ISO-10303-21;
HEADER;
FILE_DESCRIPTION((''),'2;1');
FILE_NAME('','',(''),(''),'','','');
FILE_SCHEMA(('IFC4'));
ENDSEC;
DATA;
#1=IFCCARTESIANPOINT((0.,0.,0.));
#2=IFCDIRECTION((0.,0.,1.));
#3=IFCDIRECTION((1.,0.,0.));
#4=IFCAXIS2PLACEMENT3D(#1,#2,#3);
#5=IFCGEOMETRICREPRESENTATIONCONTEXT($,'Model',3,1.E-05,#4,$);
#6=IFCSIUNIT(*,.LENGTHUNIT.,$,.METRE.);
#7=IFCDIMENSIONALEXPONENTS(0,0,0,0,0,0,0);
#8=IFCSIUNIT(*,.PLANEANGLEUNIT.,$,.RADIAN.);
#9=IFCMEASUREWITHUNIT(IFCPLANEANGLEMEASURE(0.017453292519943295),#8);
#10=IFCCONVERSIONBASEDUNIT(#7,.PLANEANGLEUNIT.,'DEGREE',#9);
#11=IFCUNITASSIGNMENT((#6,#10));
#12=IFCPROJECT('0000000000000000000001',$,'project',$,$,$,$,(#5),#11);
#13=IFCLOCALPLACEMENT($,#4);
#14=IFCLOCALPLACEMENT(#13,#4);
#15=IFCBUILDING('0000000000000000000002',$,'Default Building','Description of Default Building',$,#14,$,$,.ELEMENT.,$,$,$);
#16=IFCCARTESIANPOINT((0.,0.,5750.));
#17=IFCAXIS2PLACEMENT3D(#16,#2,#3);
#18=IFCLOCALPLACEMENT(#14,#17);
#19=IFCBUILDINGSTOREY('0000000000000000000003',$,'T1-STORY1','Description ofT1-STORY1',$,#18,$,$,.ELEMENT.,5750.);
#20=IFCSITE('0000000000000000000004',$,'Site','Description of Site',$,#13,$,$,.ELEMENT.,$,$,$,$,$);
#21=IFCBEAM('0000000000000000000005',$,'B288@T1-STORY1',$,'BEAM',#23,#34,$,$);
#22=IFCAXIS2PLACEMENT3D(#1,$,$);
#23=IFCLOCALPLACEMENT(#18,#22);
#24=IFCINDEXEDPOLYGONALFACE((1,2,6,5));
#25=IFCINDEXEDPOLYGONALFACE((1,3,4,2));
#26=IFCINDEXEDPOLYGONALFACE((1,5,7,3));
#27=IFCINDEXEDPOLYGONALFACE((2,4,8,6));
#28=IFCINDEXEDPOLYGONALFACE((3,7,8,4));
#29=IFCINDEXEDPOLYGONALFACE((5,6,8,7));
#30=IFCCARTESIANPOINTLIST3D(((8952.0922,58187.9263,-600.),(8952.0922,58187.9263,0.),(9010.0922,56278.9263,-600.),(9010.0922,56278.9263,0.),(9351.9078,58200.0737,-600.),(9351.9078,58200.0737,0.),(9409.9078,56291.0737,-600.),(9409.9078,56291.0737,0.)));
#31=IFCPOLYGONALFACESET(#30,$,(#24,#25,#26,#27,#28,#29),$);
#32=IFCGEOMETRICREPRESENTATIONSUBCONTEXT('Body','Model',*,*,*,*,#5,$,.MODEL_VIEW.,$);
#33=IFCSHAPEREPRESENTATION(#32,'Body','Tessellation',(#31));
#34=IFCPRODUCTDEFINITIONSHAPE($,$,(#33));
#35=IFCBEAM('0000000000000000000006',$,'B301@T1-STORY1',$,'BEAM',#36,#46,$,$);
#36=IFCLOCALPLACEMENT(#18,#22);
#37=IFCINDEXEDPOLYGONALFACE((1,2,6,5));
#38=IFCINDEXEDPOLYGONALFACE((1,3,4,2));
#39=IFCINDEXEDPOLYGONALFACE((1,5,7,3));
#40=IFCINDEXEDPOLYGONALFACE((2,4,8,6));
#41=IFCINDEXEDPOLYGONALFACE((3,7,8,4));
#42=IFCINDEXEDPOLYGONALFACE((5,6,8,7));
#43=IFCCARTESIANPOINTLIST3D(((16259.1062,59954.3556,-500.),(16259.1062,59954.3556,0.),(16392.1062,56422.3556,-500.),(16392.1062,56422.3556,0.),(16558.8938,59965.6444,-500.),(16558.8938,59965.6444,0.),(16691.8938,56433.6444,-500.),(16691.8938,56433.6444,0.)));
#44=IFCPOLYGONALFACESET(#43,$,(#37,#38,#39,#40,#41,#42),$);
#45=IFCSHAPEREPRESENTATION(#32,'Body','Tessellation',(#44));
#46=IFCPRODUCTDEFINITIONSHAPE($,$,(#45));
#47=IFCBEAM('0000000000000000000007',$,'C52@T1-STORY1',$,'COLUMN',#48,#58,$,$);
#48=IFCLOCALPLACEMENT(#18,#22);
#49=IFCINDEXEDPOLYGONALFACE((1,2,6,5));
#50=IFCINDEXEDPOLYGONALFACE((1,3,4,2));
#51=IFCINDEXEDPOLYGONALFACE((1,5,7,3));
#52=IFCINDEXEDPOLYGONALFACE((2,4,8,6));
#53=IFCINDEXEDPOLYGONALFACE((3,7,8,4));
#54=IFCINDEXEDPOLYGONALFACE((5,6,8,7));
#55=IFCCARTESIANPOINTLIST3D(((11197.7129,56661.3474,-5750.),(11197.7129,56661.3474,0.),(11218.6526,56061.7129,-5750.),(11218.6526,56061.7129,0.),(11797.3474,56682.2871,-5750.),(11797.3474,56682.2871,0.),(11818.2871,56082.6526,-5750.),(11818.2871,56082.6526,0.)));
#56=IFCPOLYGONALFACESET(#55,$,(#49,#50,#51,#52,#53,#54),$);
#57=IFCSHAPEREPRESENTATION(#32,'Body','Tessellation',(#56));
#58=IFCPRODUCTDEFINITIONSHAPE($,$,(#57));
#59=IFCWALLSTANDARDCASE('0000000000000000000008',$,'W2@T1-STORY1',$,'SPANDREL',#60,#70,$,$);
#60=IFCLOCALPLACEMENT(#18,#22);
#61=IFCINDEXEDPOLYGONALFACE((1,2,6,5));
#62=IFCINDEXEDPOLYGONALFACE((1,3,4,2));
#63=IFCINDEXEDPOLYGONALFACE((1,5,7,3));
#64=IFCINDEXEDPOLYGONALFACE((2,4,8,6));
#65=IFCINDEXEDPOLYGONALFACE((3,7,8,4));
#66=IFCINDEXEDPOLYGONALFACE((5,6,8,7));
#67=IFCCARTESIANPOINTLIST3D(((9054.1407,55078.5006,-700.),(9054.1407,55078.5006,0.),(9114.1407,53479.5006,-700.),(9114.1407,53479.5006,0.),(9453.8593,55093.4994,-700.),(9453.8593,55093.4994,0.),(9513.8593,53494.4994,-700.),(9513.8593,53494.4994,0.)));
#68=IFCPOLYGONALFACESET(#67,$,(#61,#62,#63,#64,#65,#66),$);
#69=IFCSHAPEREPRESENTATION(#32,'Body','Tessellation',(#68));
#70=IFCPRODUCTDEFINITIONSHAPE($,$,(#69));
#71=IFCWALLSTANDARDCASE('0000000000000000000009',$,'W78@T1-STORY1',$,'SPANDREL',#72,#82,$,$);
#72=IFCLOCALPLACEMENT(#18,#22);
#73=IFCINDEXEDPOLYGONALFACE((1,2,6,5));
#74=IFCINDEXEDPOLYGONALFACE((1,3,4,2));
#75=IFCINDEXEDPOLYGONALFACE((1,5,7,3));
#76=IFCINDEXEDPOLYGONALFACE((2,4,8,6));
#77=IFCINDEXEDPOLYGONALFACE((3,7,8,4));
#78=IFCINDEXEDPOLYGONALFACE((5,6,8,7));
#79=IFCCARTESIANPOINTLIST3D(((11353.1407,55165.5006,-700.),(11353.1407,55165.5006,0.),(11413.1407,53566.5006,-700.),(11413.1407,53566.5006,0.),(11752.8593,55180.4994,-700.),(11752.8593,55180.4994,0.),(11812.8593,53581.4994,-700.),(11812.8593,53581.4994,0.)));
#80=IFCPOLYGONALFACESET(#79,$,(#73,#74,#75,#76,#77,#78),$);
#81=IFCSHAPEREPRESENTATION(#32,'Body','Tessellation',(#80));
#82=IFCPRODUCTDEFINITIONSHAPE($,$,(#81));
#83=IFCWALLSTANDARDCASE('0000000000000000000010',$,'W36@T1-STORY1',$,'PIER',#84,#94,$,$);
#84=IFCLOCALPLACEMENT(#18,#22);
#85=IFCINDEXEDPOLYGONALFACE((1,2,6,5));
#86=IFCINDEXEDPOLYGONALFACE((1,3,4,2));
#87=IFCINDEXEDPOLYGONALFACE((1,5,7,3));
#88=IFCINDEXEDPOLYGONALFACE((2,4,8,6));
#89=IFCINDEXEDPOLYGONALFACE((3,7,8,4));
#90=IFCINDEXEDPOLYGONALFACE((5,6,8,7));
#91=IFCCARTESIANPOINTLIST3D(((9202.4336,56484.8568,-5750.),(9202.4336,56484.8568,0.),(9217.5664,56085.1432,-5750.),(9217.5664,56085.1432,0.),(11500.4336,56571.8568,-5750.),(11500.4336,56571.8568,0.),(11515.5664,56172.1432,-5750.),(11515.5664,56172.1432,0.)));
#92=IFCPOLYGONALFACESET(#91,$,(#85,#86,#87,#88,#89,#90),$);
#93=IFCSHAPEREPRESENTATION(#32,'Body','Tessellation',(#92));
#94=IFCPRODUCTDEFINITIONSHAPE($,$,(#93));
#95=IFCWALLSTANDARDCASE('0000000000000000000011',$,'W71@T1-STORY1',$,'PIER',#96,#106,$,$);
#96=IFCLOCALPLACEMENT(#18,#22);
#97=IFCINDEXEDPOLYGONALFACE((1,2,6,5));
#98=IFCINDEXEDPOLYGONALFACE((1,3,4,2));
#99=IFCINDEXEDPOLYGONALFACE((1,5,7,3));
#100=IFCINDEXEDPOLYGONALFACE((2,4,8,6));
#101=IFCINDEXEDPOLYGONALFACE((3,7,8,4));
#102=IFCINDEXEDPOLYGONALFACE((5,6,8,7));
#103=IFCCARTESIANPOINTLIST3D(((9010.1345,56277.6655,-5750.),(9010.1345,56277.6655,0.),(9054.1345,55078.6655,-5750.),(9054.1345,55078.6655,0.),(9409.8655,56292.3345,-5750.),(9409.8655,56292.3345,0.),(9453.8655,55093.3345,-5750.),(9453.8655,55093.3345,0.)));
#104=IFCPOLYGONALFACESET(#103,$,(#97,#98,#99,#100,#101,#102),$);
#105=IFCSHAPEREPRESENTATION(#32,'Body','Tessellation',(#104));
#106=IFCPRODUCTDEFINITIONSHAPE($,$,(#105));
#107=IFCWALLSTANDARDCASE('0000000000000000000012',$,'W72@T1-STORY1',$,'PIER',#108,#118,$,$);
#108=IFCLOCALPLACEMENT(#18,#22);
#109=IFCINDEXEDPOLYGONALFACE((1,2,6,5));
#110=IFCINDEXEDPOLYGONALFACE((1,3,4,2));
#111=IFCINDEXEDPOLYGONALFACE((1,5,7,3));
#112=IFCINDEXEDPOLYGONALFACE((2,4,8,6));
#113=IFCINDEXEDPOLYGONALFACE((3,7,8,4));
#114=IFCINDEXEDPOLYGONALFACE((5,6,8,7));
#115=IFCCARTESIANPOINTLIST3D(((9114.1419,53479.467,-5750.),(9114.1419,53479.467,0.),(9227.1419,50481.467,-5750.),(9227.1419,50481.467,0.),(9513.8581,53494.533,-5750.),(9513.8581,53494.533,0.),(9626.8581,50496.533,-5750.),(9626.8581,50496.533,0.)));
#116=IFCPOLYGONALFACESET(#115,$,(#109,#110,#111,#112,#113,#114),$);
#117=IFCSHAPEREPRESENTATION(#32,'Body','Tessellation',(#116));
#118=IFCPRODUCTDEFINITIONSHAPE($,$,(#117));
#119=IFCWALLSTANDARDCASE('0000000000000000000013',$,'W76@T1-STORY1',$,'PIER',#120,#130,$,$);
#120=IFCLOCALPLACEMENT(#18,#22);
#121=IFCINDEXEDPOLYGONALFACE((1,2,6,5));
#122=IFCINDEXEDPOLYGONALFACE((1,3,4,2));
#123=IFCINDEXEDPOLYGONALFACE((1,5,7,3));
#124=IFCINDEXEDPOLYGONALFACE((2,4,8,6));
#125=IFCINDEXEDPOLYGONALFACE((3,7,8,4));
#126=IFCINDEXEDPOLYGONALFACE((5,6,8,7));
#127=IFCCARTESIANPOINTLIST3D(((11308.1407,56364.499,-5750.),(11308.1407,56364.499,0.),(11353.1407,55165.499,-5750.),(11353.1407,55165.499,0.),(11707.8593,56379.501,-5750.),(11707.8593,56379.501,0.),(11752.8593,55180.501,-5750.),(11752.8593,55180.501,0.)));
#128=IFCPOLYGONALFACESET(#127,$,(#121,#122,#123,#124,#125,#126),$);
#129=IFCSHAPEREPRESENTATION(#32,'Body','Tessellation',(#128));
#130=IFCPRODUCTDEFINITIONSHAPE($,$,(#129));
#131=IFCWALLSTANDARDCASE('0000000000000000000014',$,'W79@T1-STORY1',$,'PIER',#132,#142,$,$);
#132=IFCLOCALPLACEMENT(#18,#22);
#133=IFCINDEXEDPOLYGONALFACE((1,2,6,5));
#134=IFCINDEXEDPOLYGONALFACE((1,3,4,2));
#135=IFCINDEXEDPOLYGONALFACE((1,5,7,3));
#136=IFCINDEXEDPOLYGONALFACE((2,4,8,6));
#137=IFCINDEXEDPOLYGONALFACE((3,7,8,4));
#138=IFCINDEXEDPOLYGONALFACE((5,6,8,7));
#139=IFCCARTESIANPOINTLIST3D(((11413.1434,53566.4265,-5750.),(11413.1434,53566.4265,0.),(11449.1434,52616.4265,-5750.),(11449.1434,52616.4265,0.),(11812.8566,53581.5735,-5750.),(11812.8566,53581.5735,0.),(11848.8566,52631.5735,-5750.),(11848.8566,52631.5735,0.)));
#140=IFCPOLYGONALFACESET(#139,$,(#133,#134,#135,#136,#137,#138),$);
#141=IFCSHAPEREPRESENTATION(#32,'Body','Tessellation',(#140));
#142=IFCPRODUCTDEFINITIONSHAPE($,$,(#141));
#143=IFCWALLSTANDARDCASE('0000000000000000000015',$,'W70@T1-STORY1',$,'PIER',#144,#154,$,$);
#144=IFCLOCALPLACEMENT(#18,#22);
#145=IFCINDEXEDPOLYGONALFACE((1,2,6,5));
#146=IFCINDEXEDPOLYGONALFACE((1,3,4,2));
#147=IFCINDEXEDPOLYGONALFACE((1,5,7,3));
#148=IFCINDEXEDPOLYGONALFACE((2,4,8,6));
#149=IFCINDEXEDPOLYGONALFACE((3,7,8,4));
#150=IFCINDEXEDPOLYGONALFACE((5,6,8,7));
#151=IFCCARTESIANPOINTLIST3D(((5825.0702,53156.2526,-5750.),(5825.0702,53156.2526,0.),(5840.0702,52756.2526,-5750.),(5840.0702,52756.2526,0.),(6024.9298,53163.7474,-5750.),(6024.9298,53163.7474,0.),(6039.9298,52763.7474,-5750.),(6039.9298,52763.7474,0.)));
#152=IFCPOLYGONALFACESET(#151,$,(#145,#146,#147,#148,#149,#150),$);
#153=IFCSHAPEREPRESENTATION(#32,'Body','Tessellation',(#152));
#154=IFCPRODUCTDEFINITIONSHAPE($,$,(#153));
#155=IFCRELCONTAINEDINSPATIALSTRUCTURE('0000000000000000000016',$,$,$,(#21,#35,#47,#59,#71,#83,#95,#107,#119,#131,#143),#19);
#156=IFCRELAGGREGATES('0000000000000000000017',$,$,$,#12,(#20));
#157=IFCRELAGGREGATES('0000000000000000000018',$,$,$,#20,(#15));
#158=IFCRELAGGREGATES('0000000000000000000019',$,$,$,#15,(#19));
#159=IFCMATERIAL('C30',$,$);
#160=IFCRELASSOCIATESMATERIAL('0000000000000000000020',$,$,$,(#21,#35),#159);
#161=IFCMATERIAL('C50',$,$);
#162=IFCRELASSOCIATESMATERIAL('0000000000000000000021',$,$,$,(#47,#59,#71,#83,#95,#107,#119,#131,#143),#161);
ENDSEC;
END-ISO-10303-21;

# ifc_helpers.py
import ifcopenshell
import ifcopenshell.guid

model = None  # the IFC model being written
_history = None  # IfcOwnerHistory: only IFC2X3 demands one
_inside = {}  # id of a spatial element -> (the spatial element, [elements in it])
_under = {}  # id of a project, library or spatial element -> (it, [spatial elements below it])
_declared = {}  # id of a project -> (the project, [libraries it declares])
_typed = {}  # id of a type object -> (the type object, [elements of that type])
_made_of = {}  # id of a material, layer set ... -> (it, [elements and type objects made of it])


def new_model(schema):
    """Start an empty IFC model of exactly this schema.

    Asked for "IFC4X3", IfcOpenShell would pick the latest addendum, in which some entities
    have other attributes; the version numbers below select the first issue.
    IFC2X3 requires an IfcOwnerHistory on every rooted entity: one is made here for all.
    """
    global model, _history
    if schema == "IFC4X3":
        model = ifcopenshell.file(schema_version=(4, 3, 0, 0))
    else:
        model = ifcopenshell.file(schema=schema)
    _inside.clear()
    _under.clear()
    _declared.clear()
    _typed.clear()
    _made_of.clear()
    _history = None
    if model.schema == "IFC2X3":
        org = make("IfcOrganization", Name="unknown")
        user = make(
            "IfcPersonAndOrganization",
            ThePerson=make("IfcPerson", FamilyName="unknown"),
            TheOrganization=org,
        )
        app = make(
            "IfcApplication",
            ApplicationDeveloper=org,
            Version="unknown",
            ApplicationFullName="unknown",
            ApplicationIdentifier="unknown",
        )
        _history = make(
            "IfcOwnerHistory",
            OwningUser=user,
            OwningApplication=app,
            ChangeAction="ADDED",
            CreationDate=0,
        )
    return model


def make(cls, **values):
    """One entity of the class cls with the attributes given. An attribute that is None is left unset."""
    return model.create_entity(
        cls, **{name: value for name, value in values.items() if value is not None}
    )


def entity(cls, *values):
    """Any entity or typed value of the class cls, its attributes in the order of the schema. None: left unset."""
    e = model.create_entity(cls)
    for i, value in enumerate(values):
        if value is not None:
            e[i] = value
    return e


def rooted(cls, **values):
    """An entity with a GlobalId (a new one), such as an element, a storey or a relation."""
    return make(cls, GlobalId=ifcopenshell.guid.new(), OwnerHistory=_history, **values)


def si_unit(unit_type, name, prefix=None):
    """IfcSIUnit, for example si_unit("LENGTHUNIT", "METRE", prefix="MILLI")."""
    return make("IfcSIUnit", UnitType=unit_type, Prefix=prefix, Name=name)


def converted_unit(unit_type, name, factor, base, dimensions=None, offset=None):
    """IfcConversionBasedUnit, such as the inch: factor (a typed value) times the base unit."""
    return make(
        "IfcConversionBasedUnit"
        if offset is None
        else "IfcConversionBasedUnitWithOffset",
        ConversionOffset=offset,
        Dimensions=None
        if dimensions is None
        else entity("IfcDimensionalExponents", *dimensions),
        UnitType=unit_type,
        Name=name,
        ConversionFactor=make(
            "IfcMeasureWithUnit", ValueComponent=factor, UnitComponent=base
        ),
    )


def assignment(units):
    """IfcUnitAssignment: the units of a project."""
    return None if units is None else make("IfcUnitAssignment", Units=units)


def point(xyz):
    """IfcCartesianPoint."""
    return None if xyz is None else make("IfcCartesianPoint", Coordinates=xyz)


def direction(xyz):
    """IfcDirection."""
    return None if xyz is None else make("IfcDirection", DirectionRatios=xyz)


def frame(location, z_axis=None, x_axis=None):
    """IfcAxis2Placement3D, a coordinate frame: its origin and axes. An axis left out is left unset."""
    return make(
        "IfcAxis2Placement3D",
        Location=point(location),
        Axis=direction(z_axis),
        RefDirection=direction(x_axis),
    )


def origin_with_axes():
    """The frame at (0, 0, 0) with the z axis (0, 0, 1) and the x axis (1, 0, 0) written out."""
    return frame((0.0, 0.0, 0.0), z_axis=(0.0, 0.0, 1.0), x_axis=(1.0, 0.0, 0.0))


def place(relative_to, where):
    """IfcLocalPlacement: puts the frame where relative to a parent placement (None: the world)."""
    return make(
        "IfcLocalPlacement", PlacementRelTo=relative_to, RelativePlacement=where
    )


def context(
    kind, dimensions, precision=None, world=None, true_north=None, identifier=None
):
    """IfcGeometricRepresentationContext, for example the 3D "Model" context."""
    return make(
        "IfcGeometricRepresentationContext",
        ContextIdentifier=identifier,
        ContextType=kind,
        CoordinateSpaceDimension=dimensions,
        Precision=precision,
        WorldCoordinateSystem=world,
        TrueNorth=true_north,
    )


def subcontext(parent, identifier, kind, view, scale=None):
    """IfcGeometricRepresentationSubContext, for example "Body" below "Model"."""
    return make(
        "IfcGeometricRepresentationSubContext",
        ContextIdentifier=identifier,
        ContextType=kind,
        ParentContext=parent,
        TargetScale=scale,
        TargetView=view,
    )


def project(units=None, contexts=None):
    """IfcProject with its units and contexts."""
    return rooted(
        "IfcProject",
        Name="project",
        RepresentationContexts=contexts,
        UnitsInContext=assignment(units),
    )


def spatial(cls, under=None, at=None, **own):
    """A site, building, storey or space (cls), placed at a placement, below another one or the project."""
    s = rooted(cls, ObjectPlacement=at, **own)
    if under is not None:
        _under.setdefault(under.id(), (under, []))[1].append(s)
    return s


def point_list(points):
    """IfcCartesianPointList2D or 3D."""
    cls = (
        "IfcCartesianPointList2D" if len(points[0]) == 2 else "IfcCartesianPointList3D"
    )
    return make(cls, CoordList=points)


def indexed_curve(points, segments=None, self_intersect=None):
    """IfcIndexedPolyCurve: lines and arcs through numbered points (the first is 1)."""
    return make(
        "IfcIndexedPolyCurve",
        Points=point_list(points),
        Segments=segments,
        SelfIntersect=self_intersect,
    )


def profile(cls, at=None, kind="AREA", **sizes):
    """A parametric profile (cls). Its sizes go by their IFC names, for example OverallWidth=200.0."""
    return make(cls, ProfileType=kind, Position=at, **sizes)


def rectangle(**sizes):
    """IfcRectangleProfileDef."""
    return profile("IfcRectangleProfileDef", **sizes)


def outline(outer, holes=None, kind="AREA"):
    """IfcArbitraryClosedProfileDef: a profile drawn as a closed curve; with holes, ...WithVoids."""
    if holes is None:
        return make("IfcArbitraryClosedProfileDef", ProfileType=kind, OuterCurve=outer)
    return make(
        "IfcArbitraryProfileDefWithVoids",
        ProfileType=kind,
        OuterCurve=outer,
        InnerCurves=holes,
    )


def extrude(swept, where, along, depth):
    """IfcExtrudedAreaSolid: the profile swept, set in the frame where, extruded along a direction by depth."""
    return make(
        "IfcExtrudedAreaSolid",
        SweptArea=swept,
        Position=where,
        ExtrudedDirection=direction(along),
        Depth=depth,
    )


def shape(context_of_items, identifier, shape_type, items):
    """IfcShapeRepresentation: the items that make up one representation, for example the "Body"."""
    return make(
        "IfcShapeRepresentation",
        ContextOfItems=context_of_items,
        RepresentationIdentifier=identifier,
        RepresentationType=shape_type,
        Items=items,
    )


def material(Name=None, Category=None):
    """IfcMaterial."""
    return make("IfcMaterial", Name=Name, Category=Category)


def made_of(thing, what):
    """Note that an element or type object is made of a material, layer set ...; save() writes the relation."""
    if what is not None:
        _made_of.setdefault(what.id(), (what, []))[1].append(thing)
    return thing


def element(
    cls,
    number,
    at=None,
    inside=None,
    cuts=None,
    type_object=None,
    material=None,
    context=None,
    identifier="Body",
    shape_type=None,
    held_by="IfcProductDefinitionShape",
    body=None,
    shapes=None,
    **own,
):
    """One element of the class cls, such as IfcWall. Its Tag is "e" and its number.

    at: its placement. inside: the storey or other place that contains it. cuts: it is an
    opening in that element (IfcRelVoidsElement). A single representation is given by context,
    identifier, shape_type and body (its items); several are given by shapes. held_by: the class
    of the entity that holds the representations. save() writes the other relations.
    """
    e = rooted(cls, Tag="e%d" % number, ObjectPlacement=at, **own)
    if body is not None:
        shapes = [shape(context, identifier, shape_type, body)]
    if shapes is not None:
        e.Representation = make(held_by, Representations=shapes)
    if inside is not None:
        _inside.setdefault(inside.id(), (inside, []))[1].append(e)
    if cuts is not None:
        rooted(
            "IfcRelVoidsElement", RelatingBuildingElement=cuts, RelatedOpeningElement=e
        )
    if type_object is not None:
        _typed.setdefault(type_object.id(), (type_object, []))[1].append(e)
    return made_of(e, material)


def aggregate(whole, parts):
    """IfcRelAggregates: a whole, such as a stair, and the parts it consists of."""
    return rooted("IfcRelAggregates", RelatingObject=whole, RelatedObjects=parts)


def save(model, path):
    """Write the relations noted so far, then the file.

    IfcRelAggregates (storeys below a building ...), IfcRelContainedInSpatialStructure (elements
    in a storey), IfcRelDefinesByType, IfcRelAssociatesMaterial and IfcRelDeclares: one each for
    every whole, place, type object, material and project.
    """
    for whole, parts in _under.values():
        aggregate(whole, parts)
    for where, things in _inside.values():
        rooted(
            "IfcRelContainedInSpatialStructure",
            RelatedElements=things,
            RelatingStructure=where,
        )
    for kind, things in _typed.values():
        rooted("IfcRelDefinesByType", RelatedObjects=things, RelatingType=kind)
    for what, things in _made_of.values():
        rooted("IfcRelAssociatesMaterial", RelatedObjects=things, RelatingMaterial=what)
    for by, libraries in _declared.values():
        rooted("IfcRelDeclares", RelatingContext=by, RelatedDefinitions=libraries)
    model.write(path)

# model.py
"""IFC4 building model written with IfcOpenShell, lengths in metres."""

from ifc_helpers import new_model, entity, si_unit, converted_unit, frame, origin_with_axes, place, context, subcontext, project, spatial, indexed_curve, rectangle, outline, extrude, material, element, save


model = new_model("IFC4")

# Units and contexts
model_context = context("Model", 3, precision=1e-05, world=origin_with_axes())
body_context = subcontext(model_context, "Body", "Model", "MODEL_VIEW")
ifc_project = project(units=[si_unit("LENGTHUNIT", "METRE"), converted_unit("PLANEANGLEUNIT", "DEGREE", entity("IfcPlaneAngleMeasure", 0.017453292519943295), si_unit("PLANEANGLEUNIT", "RADIAN"), dimensions=[0, 0, 0, 0, 0, 0, 0])], contexts=[model_context])

# Site, building, storey
site_placement = place(None, origin_with_axes())
site = spatial("IfcSite", under=ifc_project, at=site_placement, Name="Site", Description="Description of Site", CompositionType="ELEMENT")
building_placement = place(site_placement, origin_with_axes())
building = spatial("IfcBuilding", under=site, at=building_placement, Name="Default Building", Description="Description of Default Building", CompositionType="ELEMENT")
storey_placement = place(building_placement, frame((0.0, 0.0, 5750.0), z_axis=(0.0, 0.0, 1.0), x_axis=(1.0, 0.0, 0.0)))
storey = spatial("IfcBuildingStorey", under=building, at=storey_placement, Name="T1-STORY1", Description="Description ofT1-STORY1", CompositionType="ELEMENT", Elevation=5750.0)

# Beams
ifc_material_1 = material(Name="C30")
beam_1_placement = place(storey_placement, frame((9152.0, 58194.0, -300.0), z_axis=(0.030368, -0.999539, 0.0), x_axis=(0.999539, 0.030368, 0.0)))
element("IfcBeam", 1, at=beam_1_placement, inside=storey, material=ifc_material_1, Name="B288@T1-STORY1", ObjectType="BEAM", context=body_context, shape_type="SweptSolid", body=[
    extrude(rectangle(XDim=400.0, YDim=600.0), origin_with_axes(), (0.0, 0.0, 1.0), 1909.8809),
])
beam_2_placement = place(storey_placement, frame((16409.0, 59960.0, -250.0), z_axis=(0.037629, -0.999292, 0.0), x_axis=(0.999292, 0.037629, 0.0)))
element("IfcBeam", 2, at=beam_2_placement, inside=storey, material=ifc_material_1, Name="B301@T1-STORY1", ObjectType="BEAM", context=body_context, shape_type="SweptSolid", body=[
    extrude(rectangle(XDim=300.0, YDim=500.0), origin_with_axes(), (0.0, 0.0, 1.0), 3534.5032),
])
ifc_material_2 = material(Name="C50")
beam_3_placement = place(storey_placement, frame((11508.0, 56372.0, -5750.0), z_axis=(0.0, 0.0, 1.0), x_axis=(-0.999391, -0.034899, 0.0)))
element("IfcBeam", 3, at=beam_3_placement, inside=storey, material=ifc_material_2, Name="C52@T1-STORY1", ObjectType="COLUMN", context=body_context, shape_type="SweptSolid", body=[
    extrude(rectangle(XDim=600.0, YDim=600.0), origin_with_axes(), (0.0, 0.0, 1.0), 5750.0),
])

# Walls
for number, where, z_axis, x_axis, name in (
    (4, (9254.0, 55086.0, -700.0), (0.0, 0.0, 1.0), (0.037497, -0.999297, 0.0), "W2@T1-STORY1"),
    (5, (11553.0, 55173.0, -700.0), (0.0, 0.0, 1.0), (0.037497, -0.999297, 0.0), "W78@T1-STORY1"),
):
    element("IfcWallStandardCase", number, at=place(storey_placement, frame(where, z_axis=z_axis, x_axis=x_axis)), inside=storey, material=ifc_material_2, Name=name, ObjectType="SPANDREL", context=body_context, shape_type="SweptSolid", body=[
        extrude(outline(indexed_curve([(0.0, -200.0), (0.0, 200.0), (1600.1253, 200.0), (1600.1253, -200.0), (0.0, -200.0)], self_intersect=False)), origin_with_axes(), (0.0, 0.0, 1.0), 700.0),
    ])
wall_1_placement = place(storey_placement, frame((9210.0, 56285.0, -5750.0), z_axis=(0.0, 0.0, 1.0), x_axis=(0.999284, 0.037832, 0.0)))
element("IfcWallStandardCase", 6, at=wall_1_placement, inside=storey, material=ifc_material_2, Name="W36@T1-STORY1", ObjectType="PIER", context=body_context, shape_type="SweptSolid", body=[
    extrude(outline(indexed_curve([(0.0, -200.0), (0.0, 200.0), (2299.6463, 200.0), (2299.6463, -200.0), (0.0, -200.0)], self_intersect=False)), origin_with_axes(), (0.0, 0.0, 1.0), 5750.0),
])
wall_2_placement = place(storey_placement, frame((9210.0, 56285.0, -5750.0), z_axis=(0.0, 0.0, 1.0), x_axis=(0.036673, -0.999327, 0.0)))
element("IfcWallStandardCase", 7, at=wall_2_placement, inside=storey, material=ifc_material_2, Name="W71@T1-STORY1", ObjectType="PIER", context=body_context, shape_type="SweptSolid", body=[
    extrude(outline(indexed_curve([(0.0, -200.0), (0.0, 200.0), (1199.8071, 200.0), (1199.8071, -200.0), (0.0, -200.0)], self_intersect=False)), origin_with_axes(), (0.0, 0.0, 1.0), 5750.0),
])
wall_3_placement = place(storey_placement, frame((9314.0, 53487.0, -5750.0), z_axis=(0.0, 0.0, 1.0), x_axis=(0.037665, -0.99929, 0.0)))
element("IfcWallStandardCase", 8, at=wall_3_placement, inside=storey, material=ifc_material_2, Name="W72@T1-STORY1", ObjectType="PIER", context=body_context, shape_type="SweptSolid", body=[
    extrude(outline(indexed_curve([(0.0, -200.0), (0.0, 200.0), (3000.1288, 200.0), (3000.1288, -200.0), (0.0, -200.0)], self_intersect=False)), origin_with_axes(), (0.0, 0.0, 1.0), 5750.0),
])
wall_4_placement = place(storey_placement, frame((11508.0, 56372.0, -5750.0), z_axis=(0.0, 0.0, 1.0), x_axis=(0.037505, -0.999296, 0.0)))
element("IfcWallStandardCase", 9, at=wall_4_placement, inside=storey, material=ifc_material_2, Name="W76@T1-STORY1", ObjectType="PIER", context=body_context, shape_type="SweptSolid", body=[
    extrude(outline(indexed_curve([(0.0, -200.0), (0.0, 200.0), (1199.8442, 200.0), (1199.8442, -200.0), (0.0, -200.0)], self_intersect=False)), origin_with_axes(), (0.0, 0.0, 1.0), 5750.0),
])
wall_5_placement = place(storey_placement, frame((11613.0, 53574.0, -5750.0), z_axis=(0.0, 0.0, 1.0), x_axis=(0.037868, -0.999283, 0.0)))
element("IfcWallStandardCase", 10, at=wall_5_placement, inside=storey, material=ifc_material_2, Name="W79@T1-STORY1", ObjectType="PIER", context=body_context, shape_type="SweptSolid", body=[
    extrude(outline(indexed_curve([(0.0, -200.0), (0.0, 200.0), (950.6819, 200.0), (950.6819, -200.0), (0.0, -200.0)], self_intersect=False)), origin_with_axes(), (0.0, 0.0, 1.0), 5750.0),
])
wall_6_placement = place(storey_placement, frame((5925.0, 53160.0, -5750.0), z_axis=(0.0, 0.0, 1.0), x_axis=(0.037474, -0.999298, 0.0)))
element("IfcWallStandardCase", 11, at=wall_6_placement, inside=storey, material=ifc_material_2, Name="W70@T1-STORY1", ObjectType="PIER", context=body_context, shape_type="SweptSolid", body=[
    extrude(outline(indexed_curve([(0.0, -100.0), (0.0, 100.0), (400.2812, 100.0), (400.2812, -100.0), (0.0, -100.0)], self_intersect=False)), origin_with_axes(), (0.0, 0.0, 1.0), 5750.0),
])

save(model, "model.ifc")
